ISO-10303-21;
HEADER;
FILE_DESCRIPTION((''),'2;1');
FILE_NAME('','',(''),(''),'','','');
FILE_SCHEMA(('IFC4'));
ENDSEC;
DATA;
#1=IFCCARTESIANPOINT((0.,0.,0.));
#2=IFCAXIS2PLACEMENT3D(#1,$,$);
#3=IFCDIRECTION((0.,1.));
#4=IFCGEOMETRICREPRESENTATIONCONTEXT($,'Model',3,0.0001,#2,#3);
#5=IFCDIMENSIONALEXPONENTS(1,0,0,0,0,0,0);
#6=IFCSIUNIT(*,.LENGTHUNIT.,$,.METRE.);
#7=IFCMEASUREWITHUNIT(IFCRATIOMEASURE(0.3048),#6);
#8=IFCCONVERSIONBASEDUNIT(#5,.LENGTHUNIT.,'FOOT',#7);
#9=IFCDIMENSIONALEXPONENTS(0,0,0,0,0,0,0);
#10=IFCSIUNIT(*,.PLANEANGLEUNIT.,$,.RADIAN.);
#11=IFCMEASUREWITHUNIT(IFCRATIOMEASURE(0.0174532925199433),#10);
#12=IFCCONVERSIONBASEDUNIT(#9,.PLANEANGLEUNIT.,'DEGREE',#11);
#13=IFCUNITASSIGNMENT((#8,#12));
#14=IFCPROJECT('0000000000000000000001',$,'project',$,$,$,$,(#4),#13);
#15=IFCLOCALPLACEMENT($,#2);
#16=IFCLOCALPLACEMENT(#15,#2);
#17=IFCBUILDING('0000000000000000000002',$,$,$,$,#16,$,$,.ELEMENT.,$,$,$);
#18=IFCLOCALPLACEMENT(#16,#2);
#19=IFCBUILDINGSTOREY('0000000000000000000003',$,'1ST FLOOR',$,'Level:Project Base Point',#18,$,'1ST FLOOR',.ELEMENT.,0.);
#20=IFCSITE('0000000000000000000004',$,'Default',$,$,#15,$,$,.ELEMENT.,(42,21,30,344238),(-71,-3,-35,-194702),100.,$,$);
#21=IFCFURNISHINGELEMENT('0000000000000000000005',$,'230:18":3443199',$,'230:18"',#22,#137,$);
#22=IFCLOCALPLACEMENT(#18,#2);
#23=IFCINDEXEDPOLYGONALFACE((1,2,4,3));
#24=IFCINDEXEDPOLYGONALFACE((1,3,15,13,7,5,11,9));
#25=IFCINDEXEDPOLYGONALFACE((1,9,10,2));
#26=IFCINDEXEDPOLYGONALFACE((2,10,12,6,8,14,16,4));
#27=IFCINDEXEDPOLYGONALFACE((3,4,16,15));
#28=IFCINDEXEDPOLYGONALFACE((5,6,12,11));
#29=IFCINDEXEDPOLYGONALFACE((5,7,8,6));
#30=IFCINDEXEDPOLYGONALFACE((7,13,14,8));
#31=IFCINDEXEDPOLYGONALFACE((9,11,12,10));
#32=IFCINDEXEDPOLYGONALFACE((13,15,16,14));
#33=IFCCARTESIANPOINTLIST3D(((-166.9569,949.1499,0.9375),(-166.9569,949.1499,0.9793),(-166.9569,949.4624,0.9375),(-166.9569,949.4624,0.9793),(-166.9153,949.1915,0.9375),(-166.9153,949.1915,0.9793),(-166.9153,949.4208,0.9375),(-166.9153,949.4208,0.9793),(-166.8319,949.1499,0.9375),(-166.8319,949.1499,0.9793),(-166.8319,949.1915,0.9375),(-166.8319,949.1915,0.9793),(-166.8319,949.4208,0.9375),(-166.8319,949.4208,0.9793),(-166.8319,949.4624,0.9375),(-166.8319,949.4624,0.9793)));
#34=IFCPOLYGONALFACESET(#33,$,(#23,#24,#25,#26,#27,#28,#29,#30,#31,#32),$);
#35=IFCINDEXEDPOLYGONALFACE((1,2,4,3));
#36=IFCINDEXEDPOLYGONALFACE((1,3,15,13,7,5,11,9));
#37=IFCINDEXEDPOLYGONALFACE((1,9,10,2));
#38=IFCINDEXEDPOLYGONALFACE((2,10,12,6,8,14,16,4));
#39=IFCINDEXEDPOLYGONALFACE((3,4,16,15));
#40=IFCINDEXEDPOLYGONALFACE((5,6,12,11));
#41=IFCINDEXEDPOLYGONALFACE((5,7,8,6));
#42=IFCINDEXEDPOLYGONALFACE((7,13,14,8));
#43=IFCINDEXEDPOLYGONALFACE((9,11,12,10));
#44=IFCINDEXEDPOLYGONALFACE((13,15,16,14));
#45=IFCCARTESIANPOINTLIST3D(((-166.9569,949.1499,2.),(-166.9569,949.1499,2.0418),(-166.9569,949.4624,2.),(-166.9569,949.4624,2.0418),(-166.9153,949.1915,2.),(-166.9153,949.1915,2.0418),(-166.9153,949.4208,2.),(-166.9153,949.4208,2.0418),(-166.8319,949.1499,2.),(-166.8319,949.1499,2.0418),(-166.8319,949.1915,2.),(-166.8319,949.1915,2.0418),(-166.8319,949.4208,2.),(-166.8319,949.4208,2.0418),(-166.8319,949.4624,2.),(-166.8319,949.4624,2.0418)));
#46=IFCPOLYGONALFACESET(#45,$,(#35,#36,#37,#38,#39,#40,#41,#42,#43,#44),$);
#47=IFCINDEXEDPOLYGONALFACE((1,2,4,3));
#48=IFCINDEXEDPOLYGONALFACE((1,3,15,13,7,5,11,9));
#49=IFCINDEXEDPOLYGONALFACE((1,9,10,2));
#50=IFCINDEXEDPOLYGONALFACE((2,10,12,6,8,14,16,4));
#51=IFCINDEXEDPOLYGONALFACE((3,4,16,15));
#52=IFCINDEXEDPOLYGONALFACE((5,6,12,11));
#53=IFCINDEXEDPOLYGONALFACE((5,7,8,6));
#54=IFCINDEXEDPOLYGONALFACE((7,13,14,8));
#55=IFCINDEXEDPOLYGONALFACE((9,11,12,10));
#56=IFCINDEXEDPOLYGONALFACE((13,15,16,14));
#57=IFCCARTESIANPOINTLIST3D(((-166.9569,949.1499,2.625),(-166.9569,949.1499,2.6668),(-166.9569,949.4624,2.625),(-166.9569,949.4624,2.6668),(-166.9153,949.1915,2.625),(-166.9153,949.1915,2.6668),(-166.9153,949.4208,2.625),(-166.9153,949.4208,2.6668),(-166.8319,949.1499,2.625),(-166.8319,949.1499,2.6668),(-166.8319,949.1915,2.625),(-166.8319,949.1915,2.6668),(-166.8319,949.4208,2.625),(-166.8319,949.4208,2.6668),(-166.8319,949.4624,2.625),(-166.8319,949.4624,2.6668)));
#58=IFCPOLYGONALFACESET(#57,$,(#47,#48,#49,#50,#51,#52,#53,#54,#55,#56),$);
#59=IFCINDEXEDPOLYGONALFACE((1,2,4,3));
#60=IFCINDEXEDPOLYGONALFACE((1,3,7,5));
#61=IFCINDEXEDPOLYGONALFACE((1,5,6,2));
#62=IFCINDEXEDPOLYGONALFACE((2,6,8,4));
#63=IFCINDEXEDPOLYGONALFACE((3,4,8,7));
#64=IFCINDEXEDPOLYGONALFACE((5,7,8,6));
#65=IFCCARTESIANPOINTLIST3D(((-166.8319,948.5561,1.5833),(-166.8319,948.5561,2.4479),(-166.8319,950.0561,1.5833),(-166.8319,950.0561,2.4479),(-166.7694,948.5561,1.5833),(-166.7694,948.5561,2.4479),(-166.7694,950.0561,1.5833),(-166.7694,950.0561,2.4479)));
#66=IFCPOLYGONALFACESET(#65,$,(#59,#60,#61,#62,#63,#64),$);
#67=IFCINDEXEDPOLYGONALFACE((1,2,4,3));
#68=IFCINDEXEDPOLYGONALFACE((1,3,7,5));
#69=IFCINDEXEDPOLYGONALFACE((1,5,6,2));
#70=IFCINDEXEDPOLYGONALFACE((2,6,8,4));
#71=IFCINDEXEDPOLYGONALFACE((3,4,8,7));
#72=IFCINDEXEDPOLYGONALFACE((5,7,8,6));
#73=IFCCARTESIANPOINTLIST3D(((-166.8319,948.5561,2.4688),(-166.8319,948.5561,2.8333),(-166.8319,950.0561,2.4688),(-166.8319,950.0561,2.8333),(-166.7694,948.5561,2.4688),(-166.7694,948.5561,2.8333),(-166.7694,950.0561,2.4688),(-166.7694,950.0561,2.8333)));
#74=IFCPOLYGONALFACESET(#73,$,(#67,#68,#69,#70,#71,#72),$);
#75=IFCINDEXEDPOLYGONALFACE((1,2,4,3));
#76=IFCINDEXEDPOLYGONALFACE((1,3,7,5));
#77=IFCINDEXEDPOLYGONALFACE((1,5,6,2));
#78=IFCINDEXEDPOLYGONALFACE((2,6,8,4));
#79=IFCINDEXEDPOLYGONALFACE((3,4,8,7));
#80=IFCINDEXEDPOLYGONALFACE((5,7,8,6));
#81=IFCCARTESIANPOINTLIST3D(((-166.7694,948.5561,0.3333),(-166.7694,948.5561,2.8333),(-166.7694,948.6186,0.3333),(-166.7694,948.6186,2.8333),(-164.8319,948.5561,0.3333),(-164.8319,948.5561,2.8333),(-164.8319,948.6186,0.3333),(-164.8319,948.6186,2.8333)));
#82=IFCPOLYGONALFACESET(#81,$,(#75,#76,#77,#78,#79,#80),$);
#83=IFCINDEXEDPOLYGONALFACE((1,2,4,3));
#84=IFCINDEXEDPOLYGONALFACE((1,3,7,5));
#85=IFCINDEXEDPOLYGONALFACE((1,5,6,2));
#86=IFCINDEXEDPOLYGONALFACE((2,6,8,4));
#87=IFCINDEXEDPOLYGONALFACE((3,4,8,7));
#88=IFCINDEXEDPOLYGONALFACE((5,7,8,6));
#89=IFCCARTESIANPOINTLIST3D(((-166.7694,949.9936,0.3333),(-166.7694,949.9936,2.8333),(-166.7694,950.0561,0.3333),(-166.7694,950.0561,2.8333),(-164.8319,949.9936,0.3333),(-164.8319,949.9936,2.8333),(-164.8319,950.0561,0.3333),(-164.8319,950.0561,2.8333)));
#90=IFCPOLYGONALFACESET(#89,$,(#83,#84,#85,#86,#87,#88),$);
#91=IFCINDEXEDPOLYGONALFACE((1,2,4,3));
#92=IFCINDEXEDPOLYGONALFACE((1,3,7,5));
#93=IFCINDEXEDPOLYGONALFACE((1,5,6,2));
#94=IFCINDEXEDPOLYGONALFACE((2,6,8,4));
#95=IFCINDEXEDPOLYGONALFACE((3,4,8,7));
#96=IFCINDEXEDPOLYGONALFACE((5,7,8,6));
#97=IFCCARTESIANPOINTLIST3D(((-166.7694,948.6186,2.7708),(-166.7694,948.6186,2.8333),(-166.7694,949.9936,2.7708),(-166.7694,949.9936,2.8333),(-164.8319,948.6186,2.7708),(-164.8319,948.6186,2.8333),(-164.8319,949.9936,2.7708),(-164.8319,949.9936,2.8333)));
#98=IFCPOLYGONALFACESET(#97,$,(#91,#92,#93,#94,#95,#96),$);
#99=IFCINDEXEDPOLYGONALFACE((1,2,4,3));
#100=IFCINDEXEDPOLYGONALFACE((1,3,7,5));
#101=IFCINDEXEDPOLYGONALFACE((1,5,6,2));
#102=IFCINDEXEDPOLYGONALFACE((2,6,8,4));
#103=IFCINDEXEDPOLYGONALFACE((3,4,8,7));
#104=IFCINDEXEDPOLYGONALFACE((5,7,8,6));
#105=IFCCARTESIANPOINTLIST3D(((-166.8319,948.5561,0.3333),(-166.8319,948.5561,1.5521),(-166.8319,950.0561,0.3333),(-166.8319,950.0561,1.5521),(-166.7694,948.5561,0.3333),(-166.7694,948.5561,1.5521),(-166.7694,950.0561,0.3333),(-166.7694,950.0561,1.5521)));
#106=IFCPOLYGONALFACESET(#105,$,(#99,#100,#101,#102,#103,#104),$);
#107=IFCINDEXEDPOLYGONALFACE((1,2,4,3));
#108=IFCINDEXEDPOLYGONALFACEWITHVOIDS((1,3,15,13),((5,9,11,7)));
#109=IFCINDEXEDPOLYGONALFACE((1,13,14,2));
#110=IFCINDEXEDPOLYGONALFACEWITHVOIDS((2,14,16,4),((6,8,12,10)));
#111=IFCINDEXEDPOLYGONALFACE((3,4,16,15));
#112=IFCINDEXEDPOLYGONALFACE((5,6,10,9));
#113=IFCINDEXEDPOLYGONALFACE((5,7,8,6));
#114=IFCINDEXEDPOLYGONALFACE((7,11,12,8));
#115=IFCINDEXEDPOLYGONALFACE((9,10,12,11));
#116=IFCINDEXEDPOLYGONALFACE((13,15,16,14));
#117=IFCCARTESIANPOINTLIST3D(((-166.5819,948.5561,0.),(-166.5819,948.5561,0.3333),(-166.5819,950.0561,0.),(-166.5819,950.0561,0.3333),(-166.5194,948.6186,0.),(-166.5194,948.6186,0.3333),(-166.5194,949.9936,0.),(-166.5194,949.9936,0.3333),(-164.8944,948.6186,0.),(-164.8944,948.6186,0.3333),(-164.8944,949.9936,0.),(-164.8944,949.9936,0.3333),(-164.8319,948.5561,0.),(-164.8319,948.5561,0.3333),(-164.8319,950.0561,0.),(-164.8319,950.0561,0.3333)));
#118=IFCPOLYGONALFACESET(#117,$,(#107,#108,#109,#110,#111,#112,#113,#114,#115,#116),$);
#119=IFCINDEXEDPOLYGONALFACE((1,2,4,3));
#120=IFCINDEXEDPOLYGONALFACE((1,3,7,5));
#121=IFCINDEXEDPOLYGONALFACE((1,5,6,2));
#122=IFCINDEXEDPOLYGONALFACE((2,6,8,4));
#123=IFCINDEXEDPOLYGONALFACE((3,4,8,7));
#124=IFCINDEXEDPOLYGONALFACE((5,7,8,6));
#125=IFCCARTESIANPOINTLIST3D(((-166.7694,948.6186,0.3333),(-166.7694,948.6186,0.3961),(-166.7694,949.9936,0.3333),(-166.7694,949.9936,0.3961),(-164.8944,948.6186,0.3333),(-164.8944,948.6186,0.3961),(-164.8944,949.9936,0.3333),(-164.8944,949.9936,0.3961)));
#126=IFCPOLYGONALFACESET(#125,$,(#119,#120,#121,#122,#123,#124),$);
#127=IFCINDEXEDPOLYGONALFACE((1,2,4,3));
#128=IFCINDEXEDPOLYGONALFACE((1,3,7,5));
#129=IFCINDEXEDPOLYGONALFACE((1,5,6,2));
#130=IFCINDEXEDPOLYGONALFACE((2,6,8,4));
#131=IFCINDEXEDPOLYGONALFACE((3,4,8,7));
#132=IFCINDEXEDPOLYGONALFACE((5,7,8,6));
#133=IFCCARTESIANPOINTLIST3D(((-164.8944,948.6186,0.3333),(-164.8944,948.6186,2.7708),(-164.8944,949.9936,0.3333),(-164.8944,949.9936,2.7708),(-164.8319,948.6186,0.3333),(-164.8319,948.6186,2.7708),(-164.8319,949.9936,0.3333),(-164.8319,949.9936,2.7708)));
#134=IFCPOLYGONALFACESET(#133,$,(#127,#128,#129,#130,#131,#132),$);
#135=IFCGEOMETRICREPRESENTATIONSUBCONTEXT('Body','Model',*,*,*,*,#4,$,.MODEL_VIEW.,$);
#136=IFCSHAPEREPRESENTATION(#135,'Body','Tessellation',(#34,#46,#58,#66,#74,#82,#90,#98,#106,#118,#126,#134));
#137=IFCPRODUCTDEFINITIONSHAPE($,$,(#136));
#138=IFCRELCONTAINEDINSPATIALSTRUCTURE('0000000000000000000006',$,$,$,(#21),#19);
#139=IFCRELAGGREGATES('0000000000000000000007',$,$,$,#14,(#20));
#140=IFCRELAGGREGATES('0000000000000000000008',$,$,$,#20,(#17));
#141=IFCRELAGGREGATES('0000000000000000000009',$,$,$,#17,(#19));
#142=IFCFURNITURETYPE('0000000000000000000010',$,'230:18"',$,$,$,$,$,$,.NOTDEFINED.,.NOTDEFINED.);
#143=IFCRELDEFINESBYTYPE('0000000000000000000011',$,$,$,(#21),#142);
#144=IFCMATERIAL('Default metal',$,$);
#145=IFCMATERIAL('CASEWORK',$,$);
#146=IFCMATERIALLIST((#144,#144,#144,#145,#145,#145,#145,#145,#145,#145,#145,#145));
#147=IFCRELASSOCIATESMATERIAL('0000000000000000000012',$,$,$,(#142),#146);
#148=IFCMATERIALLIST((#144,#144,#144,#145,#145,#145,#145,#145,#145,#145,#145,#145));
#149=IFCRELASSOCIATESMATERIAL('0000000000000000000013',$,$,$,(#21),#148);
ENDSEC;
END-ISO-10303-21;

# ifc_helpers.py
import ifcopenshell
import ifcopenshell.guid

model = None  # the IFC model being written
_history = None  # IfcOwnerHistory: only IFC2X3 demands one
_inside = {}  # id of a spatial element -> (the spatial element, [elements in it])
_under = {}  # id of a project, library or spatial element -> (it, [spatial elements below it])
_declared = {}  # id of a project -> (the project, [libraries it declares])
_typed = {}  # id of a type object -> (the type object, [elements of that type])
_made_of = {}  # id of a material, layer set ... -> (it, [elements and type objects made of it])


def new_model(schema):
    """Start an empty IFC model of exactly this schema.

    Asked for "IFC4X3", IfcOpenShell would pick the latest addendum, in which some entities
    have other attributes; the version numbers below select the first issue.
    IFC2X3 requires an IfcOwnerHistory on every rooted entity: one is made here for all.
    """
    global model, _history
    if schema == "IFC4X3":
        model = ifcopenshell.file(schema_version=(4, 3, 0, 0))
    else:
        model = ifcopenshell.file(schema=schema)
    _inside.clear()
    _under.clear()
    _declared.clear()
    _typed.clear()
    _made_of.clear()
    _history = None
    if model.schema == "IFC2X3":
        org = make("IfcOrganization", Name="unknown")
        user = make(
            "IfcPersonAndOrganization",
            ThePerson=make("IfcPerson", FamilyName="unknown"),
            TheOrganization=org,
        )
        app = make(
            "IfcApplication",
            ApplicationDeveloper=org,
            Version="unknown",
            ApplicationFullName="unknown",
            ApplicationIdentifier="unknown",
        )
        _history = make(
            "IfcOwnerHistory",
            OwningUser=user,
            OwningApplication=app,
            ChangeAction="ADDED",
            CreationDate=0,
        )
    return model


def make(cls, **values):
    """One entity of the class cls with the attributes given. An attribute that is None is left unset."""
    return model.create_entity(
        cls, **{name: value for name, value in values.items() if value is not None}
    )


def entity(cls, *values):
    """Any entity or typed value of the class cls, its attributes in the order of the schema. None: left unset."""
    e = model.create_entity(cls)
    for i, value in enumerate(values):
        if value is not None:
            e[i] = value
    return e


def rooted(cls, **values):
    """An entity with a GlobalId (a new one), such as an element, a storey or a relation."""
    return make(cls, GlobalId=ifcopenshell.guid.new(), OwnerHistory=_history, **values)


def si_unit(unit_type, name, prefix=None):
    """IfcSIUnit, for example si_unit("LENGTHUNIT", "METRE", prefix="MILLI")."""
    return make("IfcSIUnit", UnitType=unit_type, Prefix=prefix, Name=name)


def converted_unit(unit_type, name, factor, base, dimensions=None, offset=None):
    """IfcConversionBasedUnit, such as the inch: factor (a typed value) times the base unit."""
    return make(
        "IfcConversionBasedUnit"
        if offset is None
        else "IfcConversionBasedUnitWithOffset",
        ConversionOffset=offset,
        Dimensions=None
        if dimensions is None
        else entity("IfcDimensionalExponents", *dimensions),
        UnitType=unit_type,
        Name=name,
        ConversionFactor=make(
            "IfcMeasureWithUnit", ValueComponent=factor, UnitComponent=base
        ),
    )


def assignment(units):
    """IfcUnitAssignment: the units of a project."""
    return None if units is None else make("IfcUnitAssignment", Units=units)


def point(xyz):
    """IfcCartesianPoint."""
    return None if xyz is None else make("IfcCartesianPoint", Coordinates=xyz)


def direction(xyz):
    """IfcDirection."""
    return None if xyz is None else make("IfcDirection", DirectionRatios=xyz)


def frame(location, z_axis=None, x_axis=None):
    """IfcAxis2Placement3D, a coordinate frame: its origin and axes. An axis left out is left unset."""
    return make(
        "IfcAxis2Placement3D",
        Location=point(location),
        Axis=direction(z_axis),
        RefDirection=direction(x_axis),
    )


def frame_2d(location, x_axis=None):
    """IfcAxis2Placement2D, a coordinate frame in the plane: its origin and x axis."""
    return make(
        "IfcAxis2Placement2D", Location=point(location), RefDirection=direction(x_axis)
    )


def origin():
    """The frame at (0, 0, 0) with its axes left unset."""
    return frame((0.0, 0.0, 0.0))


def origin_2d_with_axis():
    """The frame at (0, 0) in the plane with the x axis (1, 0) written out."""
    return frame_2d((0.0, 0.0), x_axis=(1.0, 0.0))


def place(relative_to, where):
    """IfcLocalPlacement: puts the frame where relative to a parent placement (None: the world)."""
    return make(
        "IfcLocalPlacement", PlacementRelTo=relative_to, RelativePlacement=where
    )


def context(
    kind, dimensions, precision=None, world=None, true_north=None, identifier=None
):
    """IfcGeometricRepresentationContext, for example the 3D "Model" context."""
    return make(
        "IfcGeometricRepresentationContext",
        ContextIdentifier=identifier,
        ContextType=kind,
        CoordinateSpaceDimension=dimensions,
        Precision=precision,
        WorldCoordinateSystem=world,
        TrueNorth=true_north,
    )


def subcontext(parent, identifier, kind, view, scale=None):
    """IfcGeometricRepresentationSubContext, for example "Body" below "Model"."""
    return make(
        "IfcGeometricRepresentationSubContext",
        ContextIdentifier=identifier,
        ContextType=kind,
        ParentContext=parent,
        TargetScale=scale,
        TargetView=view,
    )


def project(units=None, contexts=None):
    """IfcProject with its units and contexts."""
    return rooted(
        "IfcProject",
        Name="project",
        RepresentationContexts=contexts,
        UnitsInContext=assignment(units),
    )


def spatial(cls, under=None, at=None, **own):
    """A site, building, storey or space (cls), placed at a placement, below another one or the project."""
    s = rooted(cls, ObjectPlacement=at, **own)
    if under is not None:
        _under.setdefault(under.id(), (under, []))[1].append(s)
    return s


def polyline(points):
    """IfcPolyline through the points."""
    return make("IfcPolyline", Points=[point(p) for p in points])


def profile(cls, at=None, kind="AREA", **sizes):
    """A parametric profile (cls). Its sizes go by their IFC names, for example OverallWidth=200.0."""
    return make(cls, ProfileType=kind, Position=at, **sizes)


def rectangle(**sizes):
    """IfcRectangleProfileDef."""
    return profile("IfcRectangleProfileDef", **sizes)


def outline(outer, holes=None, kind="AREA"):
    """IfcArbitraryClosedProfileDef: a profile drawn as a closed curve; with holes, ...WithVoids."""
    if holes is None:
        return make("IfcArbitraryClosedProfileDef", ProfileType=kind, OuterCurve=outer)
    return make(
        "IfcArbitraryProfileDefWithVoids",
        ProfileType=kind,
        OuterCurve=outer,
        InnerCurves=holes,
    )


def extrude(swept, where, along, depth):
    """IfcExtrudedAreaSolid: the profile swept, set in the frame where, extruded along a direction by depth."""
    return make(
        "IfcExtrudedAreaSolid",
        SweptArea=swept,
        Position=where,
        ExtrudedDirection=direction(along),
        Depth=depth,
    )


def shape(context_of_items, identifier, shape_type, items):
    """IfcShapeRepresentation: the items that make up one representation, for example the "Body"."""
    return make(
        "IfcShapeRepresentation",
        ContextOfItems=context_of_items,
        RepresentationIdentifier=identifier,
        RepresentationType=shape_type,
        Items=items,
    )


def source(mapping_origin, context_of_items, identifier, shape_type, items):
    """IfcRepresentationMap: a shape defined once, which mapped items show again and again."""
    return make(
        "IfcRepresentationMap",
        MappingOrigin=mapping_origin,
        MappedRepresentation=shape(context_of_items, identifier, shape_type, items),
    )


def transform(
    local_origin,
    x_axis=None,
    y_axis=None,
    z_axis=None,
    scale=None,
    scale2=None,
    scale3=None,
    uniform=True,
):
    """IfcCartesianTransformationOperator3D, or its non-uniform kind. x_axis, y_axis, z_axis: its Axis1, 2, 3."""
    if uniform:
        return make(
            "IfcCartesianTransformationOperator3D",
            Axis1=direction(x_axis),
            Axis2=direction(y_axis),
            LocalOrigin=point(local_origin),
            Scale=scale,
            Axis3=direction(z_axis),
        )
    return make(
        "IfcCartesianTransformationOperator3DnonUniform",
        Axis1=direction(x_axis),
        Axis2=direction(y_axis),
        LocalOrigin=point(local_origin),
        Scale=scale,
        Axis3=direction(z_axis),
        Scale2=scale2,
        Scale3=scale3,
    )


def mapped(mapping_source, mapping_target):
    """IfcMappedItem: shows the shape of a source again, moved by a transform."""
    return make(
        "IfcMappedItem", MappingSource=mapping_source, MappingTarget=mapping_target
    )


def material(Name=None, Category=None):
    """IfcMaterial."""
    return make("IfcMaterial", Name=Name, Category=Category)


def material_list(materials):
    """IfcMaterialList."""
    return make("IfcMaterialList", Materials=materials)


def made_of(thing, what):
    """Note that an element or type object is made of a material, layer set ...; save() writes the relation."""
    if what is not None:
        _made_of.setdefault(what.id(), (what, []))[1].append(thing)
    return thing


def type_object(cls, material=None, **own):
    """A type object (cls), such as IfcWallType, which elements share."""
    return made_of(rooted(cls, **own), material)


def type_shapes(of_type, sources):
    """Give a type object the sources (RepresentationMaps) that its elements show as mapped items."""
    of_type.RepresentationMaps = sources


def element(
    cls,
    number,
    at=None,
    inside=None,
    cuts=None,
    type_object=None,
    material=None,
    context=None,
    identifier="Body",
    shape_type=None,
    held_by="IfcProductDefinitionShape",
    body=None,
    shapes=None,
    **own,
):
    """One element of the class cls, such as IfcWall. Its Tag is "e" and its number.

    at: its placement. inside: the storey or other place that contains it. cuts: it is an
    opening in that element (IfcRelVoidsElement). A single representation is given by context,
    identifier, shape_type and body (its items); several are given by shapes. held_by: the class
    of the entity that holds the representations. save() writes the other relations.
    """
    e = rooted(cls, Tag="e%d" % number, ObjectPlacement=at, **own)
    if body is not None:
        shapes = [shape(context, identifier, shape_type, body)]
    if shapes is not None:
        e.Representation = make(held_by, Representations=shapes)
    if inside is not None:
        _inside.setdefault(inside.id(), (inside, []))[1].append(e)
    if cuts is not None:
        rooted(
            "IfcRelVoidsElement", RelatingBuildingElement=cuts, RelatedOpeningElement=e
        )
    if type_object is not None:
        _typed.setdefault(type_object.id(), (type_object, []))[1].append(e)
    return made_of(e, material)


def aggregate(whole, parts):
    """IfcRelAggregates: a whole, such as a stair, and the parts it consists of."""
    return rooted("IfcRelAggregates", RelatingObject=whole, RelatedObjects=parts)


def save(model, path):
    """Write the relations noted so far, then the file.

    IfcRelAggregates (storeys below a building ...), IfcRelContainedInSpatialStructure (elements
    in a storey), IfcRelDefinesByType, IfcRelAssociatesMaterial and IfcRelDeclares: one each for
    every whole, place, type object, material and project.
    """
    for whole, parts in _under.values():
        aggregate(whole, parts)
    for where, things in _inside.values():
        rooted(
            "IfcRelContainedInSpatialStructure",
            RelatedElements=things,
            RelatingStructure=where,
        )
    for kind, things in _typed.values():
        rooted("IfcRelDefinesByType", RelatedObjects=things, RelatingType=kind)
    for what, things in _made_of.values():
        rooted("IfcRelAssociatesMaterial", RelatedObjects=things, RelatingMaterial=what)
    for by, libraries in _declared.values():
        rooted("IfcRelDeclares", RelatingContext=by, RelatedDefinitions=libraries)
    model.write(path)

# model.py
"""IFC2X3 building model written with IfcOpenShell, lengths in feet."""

from ifc_helpers import new_model, entity, si_unit, converted_unit, direction, frame, frame_2d, origin, origin_2d_with_axis, place, context, subcontext, project, spatial, polyline, rectangle, outline, extrude, source, transform, mapped, material, material_list, type_object, type_shapes, element, save


model = new_model("IFC2X3")

# Units and contexts
model_context = context("Model", 3, precision=0.0001, world=origin(), true_north=direction((0.0, 1.0)))
body_context = subcontext(model_context, "Body", "Model", "MODEL_VIEW")
ifc_project = project(units=[converted_unit("LENGTHUNIT", "FOOT", entity("IfcRatioMeasure", 0.3048), si_unit("LENGTHUNIT", "METRE"), dimensions=[1, 0, 0, 0, 0, 0, 0]), converted_unit("PLANEANGLEUNIT", "DEGREE", entity("IfcRatioMeasure", 0.0174532925199433), si_unit("PLANEANGLEUNIT", "RADIAN"), dimensions=[0, 0, 0, 0, 0, 0, 0])], contexts=[model_context])

# Site, building, storey
site_placement = place(None, origin())
site = spatial("IfcSite", under=ifc_project, at=site_placement, Name="Default", CompositionType="ELEMENT", RefLatitude=(42, 21, 30, 344238), RefLongitude=(-71, -3, -35, -194702), RefElevation=100.0)
building_placement = place(site_placement, origin())
building = spatial("IfcBuilding", under=site, at=building_placement, CompositionType="ELEMENT")
storey_placement = place(building_placement, origin())
storey = spatial("IfcBuildingStorey", under=building, at=storey_placement, Name="1ST FLOOR", ObjectType="Level:Project Base Point", LongName="1ST FLOOR", CompositionType="ELEMENT", Elevation=0.0)

# Shared definitions
ifc_material_1 = material(Name="CASEWORK")

# Furnishing element
ifc_material_2 = material(Name="Default metal")
ifc_material_list_1 = material_list([ifc_material_2, ifc_material_2, ifc_material_2, ifc_material_1, ifc_material_1, ifc_material_1, ifc_material_1, ifc_material_1, ifc_material_1, ifc_material_1, ifc_material_1, ifc_material_1])
ifc_material_list_2 = material_list([ifc_material_2, ifc_material_2, ifc_material_2, ifc_material_1, ifc_material_1, ifc_material_1, ifc_material_1, ifc_material_1, ifc_material_1, ifc_material_1, ifc_material_1, ifc_material_1])
furniture_type_1 = type_object("IfcFurnitureType", Name="230:18\"", material=ifc_material_list_2)
shared_shape_1 = source(origin(), body_context, "Body", "SweptSolid", [
    extrude(outline(polyline([(-0.1562, -0.0521), (-0.1146, -0.0521), (-0.1146, 0.0313), (0.1146, 0.0313), (0.1146, -0.0521), (0.1562, -0.0521), (0.1562, 0.0729), (-0.1562, 0.0729), (-0.1562, -0.0521)])), frame((0.0615, 2.0521, 0.9375)), (0.0, 0.0, 1.0), 0.0418),
    extrude(outline(polyline([(-0.1562, -0.0521), (-0.1146, -0.0521), (-0.1146, 0.0313), (0.1146, 0.0313), (0.1146, -0.0521), (0.1562, -0.0521), (0.1562, 0.0729), (-0.1562, 0.0729), (-0.1562, -0.0521)])), frame((0.0615, 2.0521, 2.0)), (0.0, 0.0, 1.0), 0.0418),
    extrude(outline(polyline([(-0.1562, -0.0521), (-0.1146, -0.0521), (-0.1146, 0.0313), (0.1146, 0.0313), (0.1146, -0.0521), (0.1562, -0.0521), (0.1562, 0.0729), (-0.1562, 0.0729), (-0.1562, -0.0521)])), frame((0.0615, 2.0521, 2.625)), (0.0, 0.0, 1.0), 0.0418),
    extrude(rectangle(XDim=1.5, YDim=0.0625, at=frame_2d((0.0, 0.0), x_axis=(1.0, 0.0))), frame((0.0615, 1.9688, 1.5833), z_axis=(0.0, 0.0, 1.0), x_axis=(-1.0, 0.0, 0.0)), (0.0, 0.0, 1.0), 0.8646),
    extrude(rectangle(XDim=1.5, YDim=0.0625, at=frame_2d((0.0, 0.0), x_axis=(1.0, 0.0))), frame((0.0615, 1.9688, 2.4688), z_axis=(0.0, 0.0, 1.0), x_axis=(-1.0, 0.0, 0.0)), (0.0, 0.0, 1.0), 0.3646),
    extrude(rectangle(XDim=1.9375, YDim=0.0625, at=frame_2d((0.0, 0.0), x_axis=(1.0, 0.0))), frame((-0.6573, 0.9687, 0.3333), z_axis=(0.0, 0.0, 1.0), x_axis=(0.0, -1.0, 0.0)), (0.0, 0.0, 1.0), 2.5),
    extrude(rectangle(XDim=1.9375, YDim=0.0625, at=frame_2d((0.0, 0.0), x_axis=(1.0, 0.0))), frame((0.7802, 0.9687, 0.3333), z_axis=(0.0, 0.0, 1.0), x_axis=(0.0, -1.0, 0.0)), (0.0, 0.0, 1.0), 2.5),
    extrude(rectangle(XDim=1.9375, YDim=1.375, at=origin_2d_with_axis()), frame((0.0615, 0.9687, 2.7708), z_axis=(0.0, 0.0, 1.0), x_axis=(0.0, 1.0, 0.0)), (0.0, 0.0, 1.0), 0.0625),
    extrude(rectangle(XDim=1.5, YDim=0.0625, at=frame_2d((0.0, 0.0), x_axis=(1.0, 0.0))), frame((0.0615, 1.9688, 0.3333), z_axis=(0.0, 0.0, 1.0), x_axis=(-1.0, 0.0, 0.0)), (0.0, 0.0, 1.0), 1.2187),
    extrude(outline(polyline([(-0.875, -0.75), (0.875, -0.75), (0.875, 0.75), (-0.875, 0.75), (-0.875, -0.75)]), holes=[polyline([(-0.8125, -0.6875), (-0.8125, 0.6875), (0.8125, 0.6875), (0.8125, -0.6875), (-0.8125, -0.6875)])]), frame((0.0615, 0.875, 0.0), z_axis=(0.0, 0.0, 1.0), x_axis=(0.0, -1.0, 0.0)), (0.0, 0.0, 1.0), 0.3333),
    extrude(rectangle(XDim=1.875, YDim=1.375, at=origin_2d_with_axis()), frame((0.0615, 1.0, 0.3333), z_axis=(0.0, 0.0, 1.0), x_axis=(0.0, 1.0, 0.0)), (0.0, 0.0, 1.0), 0.0627),
    extrude(rectangle(XDim=1.375, YDim=0.0625, at=origin_2d_with_axis()), frame((0.0615, 0.0312, 0.3333), z_axis=(0.0, 0.0, 1.0), x_axis=(-1.0, 0.0, 0.0)), (0.0, 0.0, 1.0), 2.4375),
])
type_shapes(furniture_type_1, [shared_shape_1])
furnishing_1_placement = place(storey_placement, frame((-164.8319, 949.2447, 0.0), z_axis=(0.0, 0.0, 1.0), x_axis=(0.0, 1.0, 0.0)))
element("IfcFurnishingElement", 1, at=furnishing_1_placement, inside=storey, type_object=furniture_type_1, material=ifc_material_list_1, Name="230:18\":3443199", ObjectType="230:18\"", context=body_context, shape_type="MappedRepresentation", body=[
    mapped(shared_shape_1, transform((0.0, 0.0, 0.0), scale=1.0)),
])

save(model, "model.ifc")
